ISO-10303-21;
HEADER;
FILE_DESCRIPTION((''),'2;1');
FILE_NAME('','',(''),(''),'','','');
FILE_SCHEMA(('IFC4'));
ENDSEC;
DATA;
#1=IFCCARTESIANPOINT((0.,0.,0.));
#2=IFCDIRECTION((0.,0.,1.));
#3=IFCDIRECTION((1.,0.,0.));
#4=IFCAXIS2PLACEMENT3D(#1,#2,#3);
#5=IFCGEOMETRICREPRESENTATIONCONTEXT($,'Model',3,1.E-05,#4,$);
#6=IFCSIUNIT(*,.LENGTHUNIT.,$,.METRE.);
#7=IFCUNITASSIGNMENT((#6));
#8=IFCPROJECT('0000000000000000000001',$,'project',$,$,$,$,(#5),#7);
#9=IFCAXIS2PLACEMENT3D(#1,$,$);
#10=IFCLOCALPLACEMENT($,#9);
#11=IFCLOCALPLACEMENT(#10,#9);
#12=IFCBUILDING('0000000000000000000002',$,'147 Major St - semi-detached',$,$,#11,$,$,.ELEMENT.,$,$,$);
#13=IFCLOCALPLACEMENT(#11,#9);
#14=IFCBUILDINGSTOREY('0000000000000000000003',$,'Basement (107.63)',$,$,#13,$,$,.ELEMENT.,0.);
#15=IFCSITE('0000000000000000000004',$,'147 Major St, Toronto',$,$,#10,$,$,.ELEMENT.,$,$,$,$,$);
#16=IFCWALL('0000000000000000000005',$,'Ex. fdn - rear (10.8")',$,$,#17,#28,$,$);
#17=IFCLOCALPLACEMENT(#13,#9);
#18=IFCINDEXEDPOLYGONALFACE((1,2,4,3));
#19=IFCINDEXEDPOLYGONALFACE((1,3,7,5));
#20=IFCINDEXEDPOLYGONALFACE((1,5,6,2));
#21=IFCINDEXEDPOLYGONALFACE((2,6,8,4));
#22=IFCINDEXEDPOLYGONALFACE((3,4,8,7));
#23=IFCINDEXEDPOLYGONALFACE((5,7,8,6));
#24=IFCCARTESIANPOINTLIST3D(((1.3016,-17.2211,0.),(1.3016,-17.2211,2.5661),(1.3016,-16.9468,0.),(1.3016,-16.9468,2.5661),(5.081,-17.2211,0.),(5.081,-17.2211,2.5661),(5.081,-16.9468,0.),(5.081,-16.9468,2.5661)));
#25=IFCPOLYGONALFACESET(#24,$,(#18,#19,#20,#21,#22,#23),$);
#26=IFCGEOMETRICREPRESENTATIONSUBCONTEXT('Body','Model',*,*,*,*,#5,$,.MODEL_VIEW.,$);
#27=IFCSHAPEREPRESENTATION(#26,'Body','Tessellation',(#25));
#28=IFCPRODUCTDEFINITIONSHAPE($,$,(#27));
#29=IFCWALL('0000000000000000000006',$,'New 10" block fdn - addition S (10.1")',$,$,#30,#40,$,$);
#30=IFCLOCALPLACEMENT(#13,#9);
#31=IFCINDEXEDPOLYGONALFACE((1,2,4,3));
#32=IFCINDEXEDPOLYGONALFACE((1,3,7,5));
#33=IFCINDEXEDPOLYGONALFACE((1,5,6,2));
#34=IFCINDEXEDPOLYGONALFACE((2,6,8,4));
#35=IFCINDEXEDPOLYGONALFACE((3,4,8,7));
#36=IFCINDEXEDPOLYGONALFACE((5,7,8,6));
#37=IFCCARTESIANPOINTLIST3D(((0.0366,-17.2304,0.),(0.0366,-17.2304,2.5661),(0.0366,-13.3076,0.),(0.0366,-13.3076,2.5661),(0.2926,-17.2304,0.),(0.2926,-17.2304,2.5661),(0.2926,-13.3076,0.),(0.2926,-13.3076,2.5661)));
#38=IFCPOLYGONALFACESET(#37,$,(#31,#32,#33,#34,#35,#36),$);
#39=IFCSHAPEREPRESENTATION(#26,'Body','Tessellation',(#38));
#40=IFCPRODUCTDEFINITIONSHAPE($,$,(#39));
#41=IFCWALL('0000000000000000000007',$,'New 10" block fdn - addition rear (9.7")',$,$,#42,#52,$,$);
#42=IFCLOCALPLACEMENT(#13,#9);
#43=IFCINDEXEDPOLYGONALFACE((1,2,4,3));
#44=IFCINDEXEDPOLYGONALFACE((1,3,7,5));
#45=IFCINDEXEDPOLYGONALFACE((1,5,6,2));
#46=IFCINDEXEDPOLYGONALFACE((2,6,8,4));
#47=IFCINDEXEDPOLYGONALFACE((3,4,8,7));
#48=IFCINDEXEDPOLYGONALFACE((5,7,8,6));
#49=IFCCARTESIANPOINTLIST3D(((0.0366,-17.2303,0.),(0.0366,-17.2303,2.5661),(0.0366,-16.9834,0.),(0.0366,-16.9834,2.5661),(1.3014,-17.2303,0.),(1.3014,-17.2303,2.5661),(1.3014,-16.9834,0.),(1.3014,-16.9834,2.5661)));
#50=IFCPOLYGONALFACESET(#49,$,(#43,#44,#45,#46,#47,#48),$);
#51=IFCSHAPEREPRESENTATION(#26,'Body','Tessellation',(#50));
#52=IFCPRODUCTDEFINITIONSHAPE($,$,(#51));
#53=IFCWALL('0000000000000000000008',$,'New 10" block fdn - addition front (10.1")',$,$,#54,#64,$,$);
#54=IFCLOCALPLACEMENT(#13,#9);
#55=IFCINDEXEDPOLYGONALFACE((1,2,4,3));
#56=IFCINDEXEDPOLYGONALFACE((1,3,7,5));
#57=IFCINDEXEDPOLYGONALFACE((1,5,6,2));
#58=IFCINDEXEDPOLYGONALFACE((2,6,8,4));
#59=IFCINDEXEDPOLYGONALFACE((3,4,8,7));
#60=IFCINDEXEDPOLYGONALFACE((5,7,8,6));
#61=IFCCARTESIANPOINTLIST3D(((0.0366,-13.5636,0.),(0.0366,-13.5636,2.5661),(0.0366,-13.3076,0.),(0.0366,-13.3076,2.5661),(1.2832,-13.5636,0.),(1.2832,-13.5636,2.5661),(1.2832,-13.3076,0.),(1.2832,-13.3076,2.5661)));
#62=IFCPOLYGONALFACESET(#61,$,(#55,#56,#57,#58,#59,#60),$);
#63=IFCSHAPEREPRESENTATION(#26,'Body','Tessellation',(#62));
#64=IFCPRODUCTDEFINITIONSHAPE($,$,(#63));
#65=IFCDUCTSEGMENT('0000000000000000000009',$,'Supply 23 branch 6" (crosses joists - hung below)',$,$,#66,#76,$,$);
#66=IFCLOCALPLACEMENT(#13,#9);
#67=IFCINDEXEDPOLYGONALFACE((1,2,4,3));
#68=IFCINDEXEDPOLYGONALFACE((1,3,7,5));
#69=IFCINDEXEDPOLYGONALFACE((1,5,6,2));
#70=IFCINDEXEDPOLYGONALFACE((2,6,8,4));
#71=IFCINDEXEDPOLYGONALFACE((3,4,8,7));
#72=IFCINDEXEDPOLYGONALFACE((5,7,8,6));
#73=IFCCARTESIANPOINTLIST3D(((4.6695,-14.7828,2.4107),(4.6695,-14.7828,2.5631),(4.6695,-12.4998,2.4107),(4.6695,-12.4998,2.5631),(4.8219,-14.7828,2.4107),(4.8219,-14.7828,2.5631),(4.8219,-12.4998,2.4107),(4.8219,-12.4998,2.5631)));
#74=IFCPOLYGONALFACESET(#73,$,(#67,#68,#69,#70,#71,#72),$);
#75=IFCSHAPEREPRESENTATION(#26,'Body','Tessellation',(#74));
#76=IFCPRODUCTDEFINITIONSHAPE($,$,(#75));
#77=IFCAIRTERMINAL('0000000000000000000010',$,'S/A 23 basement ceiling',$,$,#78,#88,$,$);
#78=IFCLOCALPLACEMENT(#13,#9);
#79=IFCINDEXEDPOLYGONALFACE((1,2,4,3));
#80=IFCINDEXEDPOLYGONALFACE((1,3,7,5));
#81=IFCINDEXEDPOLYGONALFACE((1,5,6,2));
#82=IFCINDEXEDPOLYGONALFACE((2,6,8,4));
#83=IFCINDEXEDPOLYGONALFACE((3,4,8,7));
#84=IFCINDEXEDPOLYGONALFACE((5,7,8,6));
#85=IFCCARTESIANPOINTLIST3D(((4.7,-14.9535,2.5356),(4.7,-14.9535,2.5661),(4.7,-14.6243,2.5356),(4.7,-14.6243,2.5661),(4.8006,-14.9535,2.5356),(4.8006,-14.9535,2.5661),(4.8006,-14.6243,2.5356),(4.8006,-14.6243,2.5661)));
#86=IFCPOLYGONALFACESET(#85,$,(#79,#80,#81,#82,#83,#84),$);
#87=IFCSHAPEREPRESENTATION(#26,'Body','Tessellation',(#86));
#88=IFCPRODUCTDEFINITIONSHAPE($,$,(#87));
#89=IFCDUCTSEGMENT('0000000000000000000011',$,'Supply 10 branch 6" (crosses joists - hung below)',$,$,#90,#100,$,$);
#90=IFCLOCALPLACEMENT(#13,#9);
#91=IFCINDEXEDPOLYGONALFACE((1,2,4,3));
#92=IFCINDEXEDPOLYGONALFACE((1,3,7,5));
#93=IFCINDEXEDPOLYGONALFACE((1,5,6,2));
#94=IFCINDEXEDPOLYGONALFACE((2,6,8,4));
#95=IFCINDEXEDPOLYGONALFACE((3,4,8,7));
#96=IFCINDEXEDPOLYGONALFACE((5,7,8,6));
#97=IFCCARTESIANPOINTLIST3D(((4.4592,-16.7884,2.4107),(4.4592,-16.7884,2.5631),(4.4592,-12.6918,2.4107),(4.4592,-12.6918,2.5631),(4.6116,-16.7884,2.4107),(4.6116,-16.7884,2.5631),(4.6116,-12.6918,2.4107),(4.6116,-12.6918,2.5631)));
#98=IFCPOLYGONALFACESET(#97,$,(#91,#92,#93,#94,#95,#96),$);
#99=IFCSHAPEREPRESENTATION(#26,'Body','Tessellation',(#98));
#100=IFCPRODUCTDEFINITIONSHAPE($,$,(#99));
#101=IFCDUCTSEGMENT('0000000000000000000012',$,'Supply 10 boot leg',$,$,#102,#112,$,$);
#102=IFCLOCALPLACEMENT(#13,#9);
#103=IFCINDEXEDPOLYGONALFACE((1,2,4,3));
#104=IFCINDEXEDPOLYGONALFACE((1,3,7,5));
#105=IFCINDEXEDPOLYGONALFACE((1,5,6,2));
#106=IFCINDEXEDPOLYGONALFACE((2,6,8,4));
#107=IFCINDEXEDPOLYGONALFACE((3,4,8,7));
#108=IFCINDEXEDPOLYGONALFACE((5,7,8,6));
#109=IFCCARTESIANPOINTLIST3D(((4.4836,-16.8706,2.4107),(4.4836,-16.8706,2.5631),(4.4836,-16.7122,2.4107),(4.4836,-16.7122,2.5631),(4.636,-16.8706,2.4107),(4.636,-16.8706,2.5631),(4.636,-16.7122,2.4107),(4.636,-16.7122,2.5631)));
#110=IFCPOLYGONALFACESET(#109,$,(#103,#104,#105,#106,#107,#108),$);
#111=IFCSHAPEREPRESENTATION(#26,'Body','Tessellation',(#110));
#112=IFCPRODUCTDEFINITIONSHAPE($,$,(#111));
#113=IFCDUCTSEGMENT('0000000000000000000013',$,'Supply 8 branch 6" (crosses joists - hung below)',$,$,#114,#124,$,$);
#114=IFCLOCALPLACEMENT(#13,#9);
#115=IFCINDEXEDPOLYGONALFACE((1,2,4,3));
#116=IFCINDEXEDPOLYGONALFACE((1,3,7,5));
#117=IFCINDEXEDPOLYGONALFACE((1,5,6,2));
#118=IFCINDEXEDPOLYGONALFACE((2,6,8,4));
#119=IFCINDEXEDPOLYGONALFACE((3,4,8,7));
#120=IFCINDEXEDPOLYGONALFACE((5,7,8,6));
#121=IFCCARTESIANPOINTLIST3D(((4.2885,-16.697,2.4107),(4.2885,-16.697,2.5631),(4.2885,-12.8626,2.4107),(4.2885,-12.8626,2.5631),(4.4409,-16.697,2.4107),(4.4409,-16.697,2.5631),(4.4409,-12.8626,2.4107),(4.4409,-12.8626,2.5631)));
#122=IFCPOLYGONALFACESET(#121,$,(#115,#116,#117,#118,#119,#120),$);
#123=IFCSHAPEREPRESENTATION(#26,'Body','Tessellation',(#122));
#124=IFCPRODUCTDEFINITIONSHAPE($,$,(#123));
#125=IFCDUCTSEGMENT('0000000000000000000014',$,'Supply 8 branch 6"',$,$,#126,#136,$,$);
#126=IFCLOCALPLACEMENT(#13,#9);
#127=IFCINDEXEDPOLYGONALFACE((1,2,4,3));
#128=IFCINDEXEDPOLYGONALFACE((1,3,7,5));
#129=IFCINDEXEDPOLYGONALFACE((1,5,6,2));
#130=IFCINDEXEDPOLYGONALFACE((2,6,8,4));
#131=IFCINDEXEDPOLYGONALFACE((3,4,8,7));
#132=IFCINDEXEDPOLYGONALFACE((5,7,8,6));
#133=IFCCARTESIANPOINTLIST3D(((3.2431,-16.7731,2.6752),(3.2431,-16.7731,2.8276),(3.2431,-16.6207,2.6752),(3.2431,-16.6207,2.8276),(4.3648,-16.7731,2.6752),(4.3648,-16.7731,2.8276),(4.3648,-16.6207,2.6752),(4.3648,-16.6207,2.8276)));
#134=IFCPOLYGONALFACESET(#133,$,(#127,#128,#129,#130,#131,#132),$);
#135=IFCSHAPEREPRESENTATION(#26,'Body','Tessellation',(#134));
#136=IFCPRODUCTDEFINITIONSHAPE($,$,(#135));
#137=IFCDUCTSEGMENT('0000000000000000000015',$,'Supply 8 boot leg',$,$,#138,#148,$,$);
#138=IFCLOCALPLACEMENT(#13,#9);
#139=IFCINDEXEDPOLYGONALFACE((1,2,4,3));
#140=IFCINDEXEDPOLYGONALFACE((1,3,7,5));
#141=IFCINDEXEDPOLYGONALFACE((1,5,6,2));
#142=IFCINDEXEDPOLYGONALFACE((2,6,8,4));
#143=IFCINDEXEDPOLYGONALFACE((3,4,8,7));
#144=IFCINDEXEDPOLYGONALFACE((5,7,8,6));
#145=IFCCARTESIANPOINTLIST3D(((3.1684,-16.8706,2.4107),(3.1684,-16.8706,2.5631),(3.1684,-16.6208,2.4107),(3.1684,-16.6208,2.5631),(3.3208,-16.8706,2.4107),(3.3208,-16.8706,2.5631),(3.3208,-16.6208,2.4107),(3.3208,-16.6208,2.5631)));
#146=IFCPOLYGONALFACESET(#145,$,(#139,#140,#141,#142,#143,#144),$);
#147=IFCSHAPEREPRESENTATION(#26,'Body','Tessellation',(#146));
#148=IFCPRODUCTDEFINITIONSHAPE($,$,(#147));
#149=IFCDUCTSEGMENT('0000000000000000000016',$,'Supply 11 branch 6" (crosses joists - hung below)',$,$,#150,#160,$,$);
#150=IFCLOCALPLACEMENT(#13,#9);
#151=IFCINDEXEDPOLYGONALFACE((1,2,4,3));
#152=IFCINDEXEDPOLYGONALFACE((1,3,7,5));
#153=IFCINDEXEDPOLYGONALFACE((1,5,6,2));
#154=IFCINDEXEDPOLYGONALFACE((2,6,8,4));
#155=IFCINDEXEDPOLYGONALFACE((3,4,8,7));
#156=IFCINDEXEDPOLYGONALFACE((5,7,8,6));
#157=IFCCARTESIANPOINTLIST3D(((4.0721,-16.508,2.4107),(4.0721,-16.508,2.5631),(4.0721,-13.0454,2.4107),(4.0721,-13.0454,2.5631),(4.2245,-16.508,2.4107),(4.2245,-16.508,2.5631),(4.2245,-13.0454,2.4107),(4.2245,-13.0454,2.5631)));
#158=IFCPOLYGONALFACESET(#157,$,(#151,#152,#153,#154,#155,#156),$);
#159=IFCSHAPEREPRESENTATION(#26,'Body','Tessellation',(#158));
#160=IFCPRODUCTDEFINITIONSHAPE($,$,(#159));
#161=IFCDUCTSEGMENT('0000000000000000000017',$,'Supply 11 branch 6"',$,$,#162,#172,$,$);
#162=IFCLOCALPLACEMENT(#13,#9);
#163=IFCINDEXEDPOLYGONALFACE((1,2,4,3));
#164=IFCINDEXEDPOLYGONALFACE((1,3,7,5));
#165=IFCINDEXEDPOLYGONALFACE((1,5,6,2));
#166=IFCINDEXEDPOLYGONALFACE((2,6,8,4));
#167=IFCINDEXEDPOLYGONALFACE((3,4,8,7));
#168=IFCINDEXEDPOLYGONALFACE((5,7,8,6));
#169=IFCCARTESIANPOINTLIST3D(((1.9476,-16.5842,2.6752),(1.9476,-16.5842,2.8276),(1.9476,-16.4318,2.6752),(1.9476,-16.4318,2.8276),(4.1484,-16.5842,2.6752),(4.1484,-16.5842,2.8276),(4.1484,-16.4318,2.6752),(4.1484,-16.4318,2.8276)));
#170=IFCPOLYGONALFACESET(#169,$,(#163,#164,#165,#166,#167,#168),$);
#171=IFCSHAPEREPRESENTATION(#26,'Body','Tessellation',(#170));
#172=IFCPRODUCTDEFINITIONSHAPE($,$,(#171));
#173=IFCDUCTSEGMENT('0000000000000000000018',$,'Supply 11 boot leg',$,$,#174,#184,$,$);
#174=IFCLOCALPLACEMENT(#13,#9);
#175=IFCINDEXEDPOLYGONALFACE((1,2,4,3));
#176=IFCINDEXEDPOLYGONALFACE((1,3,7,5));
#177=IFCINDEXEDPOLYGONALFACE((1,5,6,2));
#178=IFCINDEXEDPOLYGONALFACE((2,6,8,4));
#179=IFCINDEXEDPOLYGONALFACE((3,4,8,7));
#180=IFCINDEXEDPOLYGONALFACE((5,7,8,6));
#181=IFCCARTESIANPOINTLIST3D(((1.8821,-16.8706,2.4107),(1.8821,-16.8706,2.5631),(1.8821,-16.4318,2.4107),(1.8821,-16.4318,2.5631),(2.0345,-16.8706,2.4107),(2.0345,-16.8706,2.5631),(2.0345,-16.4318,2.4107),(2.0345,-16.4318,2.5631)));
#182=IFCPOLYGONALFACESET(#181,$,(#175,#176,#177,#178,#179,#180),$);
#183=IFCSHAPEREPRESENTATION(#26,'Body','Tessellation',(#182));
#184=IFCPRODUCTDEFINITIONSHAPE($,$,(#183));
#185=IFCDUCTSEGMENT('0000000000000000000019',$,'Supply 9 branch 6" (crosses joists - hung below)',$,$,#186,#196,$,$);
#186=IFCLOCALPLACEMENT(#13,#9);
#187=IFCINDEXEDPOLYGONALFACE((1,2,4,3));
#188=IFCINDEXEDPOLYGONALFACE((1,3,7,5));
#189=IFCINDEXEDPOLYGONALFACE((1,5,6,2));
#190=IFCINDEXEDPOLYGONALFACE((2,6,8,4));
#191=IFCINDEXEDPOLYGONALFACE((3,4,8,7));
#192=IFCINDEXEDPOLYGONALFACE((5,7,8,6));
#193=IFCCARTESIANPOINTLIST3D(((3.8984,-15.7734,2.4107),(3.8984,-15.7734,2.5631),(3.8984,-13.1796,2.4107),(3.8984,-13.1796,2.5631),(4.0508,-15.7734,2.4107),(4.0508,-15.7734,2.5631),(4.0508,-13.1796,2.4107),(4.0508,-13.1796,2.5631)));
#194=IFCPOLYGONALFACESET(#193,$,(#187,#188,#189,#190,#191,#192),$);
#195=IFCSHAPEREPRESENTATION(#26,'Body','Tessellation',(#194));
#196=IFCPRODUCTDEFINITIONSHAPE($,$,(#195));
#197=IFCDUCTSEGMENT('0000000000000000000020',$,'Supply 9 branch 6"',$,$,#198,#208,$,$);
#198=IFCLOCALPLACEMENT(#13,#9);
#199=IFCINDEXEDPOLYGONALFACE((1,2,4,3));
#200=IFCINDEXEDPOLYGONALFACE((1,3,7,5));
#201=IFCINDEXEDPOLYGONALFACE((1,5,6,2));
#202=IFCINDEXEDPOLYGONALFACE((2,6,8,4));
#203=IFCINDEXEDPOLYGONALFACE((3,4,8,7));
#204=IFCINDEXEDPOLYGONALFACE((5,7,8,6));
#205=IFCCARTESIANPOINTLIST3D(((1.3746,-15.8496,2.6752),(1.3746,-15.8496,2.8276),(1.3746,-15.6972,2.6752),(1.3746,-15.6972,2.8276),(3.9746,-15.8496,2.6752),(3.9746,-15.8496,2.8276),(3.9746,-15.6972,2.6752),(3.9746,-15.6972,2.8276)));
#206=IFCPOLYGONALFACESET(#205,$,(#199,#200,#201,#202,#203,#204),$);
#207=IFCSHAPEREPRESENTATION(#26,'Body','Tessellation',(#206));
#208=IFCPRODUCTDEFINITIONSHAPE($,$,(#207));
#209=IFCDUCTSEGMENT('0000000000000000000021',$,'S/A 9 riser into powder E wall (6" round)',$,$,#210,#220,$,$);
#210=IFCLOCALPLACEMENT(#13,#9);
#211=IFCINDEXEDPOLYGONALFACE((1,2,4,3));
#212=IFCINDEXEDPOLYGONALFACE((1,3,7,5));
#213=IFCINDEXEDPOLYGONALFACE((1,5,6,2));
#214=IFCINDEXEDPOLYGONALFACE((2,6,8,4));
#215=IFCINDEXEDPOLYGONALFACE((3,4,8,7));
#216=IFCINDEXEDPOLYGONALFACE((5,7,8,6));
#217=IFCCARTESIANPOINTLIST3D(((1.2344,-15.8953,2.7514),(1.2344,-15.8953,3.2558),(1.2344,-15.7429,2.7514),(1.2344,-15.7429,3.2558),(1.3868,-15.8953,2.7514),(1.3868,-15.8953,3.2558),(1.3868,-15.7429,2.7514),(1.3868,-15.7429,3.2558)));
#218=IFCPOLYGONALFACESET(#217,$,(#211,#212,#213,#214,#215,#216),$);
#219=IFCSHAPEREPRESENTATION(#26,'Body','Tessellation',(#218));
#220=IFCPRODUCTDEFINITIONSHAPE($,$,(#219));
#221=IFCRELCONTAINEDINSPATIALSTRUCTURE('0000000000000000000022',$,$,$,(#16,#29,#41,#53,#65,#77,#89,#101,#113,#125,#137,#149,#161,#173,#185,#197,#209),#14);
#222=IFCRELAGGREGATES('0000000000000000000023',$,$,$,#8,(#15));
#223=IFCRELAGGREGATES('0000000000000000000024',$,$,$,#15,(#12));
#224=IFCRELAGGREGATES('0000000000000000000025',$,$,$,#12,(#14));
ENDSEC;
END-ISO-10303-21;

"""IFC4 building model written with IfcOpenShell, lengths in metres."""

from ifc_helpers import new_model, si_unit, frame, origin, origin_with_axes, place, context, subcontext, project, spatial, rectangle, extrude, element, save


model = new_model("IFC4")

# Units and contexts
model_context = context("Model", 3, precision=1e-05, world=origin_with_axes())
body_context = subcontext(model_context, "Body", "Model", "MODEL_VIEW")
ifc_project = project(units=[si_unit("LENGTHUNIT", "METRE")], contexts=[model_context])

# Site, building, storey
site_placement = place(None, origin())
site = spatial("IfcSite", under=ifc_project, at=site_placement, Name="147 Major St, Toronto", CompositionType="ELEMENT")
building_placement = place(site_placement, origin())
building = spatial("IfcBuilding", under=site, at=building_placement, Name="147 Major St - semi-detached", CompositionType="ELEMENT")
storey_placement = place(building_placement, origin())
storey = spatial("IfcBuildingStorey", under=building, at=storey_placement, Name="Basement (107.63)", CompositionType="ELEMENT", Elevation=0.0)

# Walls
wall_1_placement = place(storey_placement, frame((3.1913, -17.084, 0.0)))
element("IfcWall", 1, at=wall_1_placement, inside=storey, Name="Ex. fdn - rear (10.8\")", context=body_context, shape_type="SweptSolid", body=[
    extrude(rectangle(XDim=3.7795, YDim=0.2743), origin_with_axes(), (0.0, 0.0, 1.0), 2.5661),
])
wall_2_placement = place(storey_placement, frame((0.1646, -15.269, 0.0)))
element("IfcWall", 2, at=wall_2_placement, inside=storey, Name="New 10\" block fdn - addition S (10.1\")", context=body_context, shape_type="SweptSolid", body=[
    extrude(rectangle(XDim=0.256, YDim=3.9228), origin_with_axes(), (0.0, 0.0, 1.0), 2.5661),
])
wall_3_placement = place(storey_placement, frame((0.669, -17.1069, 0.0)))
element("IfcWall", 3, at=wall_3_placement, inside=storey, Name="New 10\" block fdn - addition rear (9.7\")", context=body_context, shape_type="SweptSolid", body=[
    extrude(rectangle(XDim=1.2649, YDim=0.2469), origin_with_axes(), (0.0, 0.0, 1.0), 2.5661),
])
wall_4_placement = place(storey_placement, frame((0.6599, -13.4356, 0.0)))
element("IfcWall", 4, at=wall_4_placement, inside=storey, Name="New 10\" block fdn - addition front (10.1\")", context=body_context, shape_type="SweptSolid", body=[
    extrude(rectangle(XDim=1.2466, YDim=0.256), origin_with_axes(), (0.0, 0.0, 1.0), 2.5661),
])

# Duct segment
duct_segment_1_placement = place(storey_placement, frame((4.7457, -13.6413, 2.4107)))
element("IfcDuctSegment", 5, at=duct_segment_1_placement, inside=storey, Name="Supply 23 branch 6\" (crosses joists - hung below)", context=body_context, shape_type="SweptSolid", body=[
    extrude(rectangle(XDim=0.1524, YDim=2.283), origin_with_axes(), (0.0, 0.0, 1.0), 0.1524),
])

# Air terminal
air_terminal_placement = place(storey_placement, frame((4.7503, -14.7889, 2.5356)))
element("IfcAirTerminal", 6, at=air_terminal_placement, inside=storey, Name="S/A 23 basement ceiling", context=body_context, shape_type="SweptSolid", body=[
    extrude(rectangle(XDim=0.1006, YDim=0.3292), origin_with_axes(), (0.0, 0.0, 1.0), 0.0305),
])

# Duct segments
duct_segment_2_placement = place(storey_placement, frame((4.5354, -14.7401, 2.4107)))
element("IfcDuctSegment", 7, at=duct_segment_2_placement, inside=storey, Name="Supply 10 branch 6\" (crosses joists - hung below)", context=body_context, shape_type="SweptSolid", body=[
    extrude(rectangle(XDim=0.1524, YDim=4.0965), origin_with_axes(), (0.0, 0.0, 1.0), 0.1524),
])
duct_segment_3_placement = place(storey_placement, frame((4.5598, -16.7914, 2.4107)))
element("IfcDuctSegment", 8, at=duct_segment_3_placement, inside=storey, Name="Supply 10 boot leg", context=body_context, shape_type="SweptSolid", body=[
    extrude(rectangle(XDim=0.1524, YDim=0.1585), origin_with_axes(), (0.0, 0.0, 1.0), 0.1524),
])
duct_segment_4_placement = place(storey_placement, frame((4.3647, -14.7798, 2.4107)))
element("IfcDuctSegment", 9, at=duct_segment_4_placement, inside=storey, Name="Supply 8 branch 6\" (crosses joists - hung below)", context=body_context, shape_type="SweptSolid", body=[
    extrude(rectangle(XDim=0.1524, YDim=3.8344), origin_with_axes(), (0.0, 0.0, 1.0), 0.1524),
])
duct_segment_5_placement = place(storey_placement, frame((3.8039, -16.6969, 2.6752)))
element("IfcDuctSegment", 10, at=duct_segment_5_placement, inside=storey, Name="Supply 8 branch 6\"", context=body_context, shape_type="SweptSolid", body=[
    extrude(rectangle(XDim=1.1217, YDim=0.1524), origin_with_axes(), (0.0, 0.0, 1.0), 0.1524),
])
duct_segment_6_placement = place(storey_placement, frame((3.2446, -16.7457, 2.4107)))
element("IfcDuctSegment", 11, at=duct_segment_6_placement, inside=storey, Name="Supply 8 boot leg", context=body_context, shape_type="SweptSolid", body=[
    extrude(rectangle(XDim=0.1524, YDim=0.2499), origin_with_axes(), (0.0, 0.0, 1.0), 0.1524),
])
duct_segment_7_placement = place(storey_placement, frame((4.1483, -14.7767, 2.4107)))
element("IfcDuctSegment", 12, at=duct_segment_7_placement, inside=storey, Name="Supply 11 branch 6\" (crosses joists - hung below)", context=body_context, shape_type="SweptSolid", body=[
    extrude(rectangle(XDim=0.1524, YDim=3.4625), origin_with_axes(), (0.0, 0.0, 1.0), 0.1524),
])
duct_segment_8_placement = place(storey_placement, frame((3.048, -16.508, 2.6752)))
element("IfcDuctSegment", 13, at=duct_segment_8_placement, inside=storey, Name="Supply 11 branch 6\"", context=body_context, shape_type="SweptSolid", body=[
    extrude(rectangle(XDim=2.2007, YDim=0.1524), origin_with_axes(), (0.0, 0.0, 1.0), 0.1524),
])
duct_segment_9_placement = place(storey_placement, frame((1.9583, -16.6512, 2.4107)))
element("IfcDuctSegment", 14, at=duct_segment_9_placement, inside=storey, Name="Supply 11 boot leg", context=body_context, shape_type="SweptSolid", body=[
    extrude(rectangle(XDim=0.1524, YDim=0.4389), origin_with_axes(), (0.0, 0.0, 1.0), 0.1524),
])
duct_segment_10_placement = place(storey_placement, frame((3.9746, -14.4765, 2.4107)))
element("IfcDuctSegment", 15, at=duct_segment_10_placement, inside=storey, Name="Supply 9 branch 6\" (crosses joists - hung below)", context=body_context, shape_type="SweptSolid", body=[
    extrude(rectangle(XDim=0.1524, YDim=2.5938), origin_with_axes(), (0.0, 0.0, 1.0), 0.1524),
])
duct_segment_11_placement = place(storey_placement, frame((2.6746, -15.7734, 2.6752)))
element("IfcDuctSegment", 16, at=duct_segment_11_placement, inside=storey, Name="Supply 9 branch 6\"", context=body_context, shape_type="SweptSolid", body=[
    extrude(rectangle(XDim=2.5999, YDim=0.1524), origin_with_axes(), (0.0, 0.0, 1.0), 0.1524),
])
duct_segment_12_placement = place(storey_placement, frame((1.3106, -15.8191, 2.7514)))
element("IfcDuctSegment", 17, at=duct_segment_12_placement, inside=storey, Name="S/A 9 riser into powder E wall (6\" round)", context=body_context, shape_type="SweptSolid", body=[
    extrude(rectangle(XDim=0.1524, YDim=0.1524), origin_with_axes(), (0.0, 0.0, 1.0), 0.5044),
])

save(model, "model.ifc")
